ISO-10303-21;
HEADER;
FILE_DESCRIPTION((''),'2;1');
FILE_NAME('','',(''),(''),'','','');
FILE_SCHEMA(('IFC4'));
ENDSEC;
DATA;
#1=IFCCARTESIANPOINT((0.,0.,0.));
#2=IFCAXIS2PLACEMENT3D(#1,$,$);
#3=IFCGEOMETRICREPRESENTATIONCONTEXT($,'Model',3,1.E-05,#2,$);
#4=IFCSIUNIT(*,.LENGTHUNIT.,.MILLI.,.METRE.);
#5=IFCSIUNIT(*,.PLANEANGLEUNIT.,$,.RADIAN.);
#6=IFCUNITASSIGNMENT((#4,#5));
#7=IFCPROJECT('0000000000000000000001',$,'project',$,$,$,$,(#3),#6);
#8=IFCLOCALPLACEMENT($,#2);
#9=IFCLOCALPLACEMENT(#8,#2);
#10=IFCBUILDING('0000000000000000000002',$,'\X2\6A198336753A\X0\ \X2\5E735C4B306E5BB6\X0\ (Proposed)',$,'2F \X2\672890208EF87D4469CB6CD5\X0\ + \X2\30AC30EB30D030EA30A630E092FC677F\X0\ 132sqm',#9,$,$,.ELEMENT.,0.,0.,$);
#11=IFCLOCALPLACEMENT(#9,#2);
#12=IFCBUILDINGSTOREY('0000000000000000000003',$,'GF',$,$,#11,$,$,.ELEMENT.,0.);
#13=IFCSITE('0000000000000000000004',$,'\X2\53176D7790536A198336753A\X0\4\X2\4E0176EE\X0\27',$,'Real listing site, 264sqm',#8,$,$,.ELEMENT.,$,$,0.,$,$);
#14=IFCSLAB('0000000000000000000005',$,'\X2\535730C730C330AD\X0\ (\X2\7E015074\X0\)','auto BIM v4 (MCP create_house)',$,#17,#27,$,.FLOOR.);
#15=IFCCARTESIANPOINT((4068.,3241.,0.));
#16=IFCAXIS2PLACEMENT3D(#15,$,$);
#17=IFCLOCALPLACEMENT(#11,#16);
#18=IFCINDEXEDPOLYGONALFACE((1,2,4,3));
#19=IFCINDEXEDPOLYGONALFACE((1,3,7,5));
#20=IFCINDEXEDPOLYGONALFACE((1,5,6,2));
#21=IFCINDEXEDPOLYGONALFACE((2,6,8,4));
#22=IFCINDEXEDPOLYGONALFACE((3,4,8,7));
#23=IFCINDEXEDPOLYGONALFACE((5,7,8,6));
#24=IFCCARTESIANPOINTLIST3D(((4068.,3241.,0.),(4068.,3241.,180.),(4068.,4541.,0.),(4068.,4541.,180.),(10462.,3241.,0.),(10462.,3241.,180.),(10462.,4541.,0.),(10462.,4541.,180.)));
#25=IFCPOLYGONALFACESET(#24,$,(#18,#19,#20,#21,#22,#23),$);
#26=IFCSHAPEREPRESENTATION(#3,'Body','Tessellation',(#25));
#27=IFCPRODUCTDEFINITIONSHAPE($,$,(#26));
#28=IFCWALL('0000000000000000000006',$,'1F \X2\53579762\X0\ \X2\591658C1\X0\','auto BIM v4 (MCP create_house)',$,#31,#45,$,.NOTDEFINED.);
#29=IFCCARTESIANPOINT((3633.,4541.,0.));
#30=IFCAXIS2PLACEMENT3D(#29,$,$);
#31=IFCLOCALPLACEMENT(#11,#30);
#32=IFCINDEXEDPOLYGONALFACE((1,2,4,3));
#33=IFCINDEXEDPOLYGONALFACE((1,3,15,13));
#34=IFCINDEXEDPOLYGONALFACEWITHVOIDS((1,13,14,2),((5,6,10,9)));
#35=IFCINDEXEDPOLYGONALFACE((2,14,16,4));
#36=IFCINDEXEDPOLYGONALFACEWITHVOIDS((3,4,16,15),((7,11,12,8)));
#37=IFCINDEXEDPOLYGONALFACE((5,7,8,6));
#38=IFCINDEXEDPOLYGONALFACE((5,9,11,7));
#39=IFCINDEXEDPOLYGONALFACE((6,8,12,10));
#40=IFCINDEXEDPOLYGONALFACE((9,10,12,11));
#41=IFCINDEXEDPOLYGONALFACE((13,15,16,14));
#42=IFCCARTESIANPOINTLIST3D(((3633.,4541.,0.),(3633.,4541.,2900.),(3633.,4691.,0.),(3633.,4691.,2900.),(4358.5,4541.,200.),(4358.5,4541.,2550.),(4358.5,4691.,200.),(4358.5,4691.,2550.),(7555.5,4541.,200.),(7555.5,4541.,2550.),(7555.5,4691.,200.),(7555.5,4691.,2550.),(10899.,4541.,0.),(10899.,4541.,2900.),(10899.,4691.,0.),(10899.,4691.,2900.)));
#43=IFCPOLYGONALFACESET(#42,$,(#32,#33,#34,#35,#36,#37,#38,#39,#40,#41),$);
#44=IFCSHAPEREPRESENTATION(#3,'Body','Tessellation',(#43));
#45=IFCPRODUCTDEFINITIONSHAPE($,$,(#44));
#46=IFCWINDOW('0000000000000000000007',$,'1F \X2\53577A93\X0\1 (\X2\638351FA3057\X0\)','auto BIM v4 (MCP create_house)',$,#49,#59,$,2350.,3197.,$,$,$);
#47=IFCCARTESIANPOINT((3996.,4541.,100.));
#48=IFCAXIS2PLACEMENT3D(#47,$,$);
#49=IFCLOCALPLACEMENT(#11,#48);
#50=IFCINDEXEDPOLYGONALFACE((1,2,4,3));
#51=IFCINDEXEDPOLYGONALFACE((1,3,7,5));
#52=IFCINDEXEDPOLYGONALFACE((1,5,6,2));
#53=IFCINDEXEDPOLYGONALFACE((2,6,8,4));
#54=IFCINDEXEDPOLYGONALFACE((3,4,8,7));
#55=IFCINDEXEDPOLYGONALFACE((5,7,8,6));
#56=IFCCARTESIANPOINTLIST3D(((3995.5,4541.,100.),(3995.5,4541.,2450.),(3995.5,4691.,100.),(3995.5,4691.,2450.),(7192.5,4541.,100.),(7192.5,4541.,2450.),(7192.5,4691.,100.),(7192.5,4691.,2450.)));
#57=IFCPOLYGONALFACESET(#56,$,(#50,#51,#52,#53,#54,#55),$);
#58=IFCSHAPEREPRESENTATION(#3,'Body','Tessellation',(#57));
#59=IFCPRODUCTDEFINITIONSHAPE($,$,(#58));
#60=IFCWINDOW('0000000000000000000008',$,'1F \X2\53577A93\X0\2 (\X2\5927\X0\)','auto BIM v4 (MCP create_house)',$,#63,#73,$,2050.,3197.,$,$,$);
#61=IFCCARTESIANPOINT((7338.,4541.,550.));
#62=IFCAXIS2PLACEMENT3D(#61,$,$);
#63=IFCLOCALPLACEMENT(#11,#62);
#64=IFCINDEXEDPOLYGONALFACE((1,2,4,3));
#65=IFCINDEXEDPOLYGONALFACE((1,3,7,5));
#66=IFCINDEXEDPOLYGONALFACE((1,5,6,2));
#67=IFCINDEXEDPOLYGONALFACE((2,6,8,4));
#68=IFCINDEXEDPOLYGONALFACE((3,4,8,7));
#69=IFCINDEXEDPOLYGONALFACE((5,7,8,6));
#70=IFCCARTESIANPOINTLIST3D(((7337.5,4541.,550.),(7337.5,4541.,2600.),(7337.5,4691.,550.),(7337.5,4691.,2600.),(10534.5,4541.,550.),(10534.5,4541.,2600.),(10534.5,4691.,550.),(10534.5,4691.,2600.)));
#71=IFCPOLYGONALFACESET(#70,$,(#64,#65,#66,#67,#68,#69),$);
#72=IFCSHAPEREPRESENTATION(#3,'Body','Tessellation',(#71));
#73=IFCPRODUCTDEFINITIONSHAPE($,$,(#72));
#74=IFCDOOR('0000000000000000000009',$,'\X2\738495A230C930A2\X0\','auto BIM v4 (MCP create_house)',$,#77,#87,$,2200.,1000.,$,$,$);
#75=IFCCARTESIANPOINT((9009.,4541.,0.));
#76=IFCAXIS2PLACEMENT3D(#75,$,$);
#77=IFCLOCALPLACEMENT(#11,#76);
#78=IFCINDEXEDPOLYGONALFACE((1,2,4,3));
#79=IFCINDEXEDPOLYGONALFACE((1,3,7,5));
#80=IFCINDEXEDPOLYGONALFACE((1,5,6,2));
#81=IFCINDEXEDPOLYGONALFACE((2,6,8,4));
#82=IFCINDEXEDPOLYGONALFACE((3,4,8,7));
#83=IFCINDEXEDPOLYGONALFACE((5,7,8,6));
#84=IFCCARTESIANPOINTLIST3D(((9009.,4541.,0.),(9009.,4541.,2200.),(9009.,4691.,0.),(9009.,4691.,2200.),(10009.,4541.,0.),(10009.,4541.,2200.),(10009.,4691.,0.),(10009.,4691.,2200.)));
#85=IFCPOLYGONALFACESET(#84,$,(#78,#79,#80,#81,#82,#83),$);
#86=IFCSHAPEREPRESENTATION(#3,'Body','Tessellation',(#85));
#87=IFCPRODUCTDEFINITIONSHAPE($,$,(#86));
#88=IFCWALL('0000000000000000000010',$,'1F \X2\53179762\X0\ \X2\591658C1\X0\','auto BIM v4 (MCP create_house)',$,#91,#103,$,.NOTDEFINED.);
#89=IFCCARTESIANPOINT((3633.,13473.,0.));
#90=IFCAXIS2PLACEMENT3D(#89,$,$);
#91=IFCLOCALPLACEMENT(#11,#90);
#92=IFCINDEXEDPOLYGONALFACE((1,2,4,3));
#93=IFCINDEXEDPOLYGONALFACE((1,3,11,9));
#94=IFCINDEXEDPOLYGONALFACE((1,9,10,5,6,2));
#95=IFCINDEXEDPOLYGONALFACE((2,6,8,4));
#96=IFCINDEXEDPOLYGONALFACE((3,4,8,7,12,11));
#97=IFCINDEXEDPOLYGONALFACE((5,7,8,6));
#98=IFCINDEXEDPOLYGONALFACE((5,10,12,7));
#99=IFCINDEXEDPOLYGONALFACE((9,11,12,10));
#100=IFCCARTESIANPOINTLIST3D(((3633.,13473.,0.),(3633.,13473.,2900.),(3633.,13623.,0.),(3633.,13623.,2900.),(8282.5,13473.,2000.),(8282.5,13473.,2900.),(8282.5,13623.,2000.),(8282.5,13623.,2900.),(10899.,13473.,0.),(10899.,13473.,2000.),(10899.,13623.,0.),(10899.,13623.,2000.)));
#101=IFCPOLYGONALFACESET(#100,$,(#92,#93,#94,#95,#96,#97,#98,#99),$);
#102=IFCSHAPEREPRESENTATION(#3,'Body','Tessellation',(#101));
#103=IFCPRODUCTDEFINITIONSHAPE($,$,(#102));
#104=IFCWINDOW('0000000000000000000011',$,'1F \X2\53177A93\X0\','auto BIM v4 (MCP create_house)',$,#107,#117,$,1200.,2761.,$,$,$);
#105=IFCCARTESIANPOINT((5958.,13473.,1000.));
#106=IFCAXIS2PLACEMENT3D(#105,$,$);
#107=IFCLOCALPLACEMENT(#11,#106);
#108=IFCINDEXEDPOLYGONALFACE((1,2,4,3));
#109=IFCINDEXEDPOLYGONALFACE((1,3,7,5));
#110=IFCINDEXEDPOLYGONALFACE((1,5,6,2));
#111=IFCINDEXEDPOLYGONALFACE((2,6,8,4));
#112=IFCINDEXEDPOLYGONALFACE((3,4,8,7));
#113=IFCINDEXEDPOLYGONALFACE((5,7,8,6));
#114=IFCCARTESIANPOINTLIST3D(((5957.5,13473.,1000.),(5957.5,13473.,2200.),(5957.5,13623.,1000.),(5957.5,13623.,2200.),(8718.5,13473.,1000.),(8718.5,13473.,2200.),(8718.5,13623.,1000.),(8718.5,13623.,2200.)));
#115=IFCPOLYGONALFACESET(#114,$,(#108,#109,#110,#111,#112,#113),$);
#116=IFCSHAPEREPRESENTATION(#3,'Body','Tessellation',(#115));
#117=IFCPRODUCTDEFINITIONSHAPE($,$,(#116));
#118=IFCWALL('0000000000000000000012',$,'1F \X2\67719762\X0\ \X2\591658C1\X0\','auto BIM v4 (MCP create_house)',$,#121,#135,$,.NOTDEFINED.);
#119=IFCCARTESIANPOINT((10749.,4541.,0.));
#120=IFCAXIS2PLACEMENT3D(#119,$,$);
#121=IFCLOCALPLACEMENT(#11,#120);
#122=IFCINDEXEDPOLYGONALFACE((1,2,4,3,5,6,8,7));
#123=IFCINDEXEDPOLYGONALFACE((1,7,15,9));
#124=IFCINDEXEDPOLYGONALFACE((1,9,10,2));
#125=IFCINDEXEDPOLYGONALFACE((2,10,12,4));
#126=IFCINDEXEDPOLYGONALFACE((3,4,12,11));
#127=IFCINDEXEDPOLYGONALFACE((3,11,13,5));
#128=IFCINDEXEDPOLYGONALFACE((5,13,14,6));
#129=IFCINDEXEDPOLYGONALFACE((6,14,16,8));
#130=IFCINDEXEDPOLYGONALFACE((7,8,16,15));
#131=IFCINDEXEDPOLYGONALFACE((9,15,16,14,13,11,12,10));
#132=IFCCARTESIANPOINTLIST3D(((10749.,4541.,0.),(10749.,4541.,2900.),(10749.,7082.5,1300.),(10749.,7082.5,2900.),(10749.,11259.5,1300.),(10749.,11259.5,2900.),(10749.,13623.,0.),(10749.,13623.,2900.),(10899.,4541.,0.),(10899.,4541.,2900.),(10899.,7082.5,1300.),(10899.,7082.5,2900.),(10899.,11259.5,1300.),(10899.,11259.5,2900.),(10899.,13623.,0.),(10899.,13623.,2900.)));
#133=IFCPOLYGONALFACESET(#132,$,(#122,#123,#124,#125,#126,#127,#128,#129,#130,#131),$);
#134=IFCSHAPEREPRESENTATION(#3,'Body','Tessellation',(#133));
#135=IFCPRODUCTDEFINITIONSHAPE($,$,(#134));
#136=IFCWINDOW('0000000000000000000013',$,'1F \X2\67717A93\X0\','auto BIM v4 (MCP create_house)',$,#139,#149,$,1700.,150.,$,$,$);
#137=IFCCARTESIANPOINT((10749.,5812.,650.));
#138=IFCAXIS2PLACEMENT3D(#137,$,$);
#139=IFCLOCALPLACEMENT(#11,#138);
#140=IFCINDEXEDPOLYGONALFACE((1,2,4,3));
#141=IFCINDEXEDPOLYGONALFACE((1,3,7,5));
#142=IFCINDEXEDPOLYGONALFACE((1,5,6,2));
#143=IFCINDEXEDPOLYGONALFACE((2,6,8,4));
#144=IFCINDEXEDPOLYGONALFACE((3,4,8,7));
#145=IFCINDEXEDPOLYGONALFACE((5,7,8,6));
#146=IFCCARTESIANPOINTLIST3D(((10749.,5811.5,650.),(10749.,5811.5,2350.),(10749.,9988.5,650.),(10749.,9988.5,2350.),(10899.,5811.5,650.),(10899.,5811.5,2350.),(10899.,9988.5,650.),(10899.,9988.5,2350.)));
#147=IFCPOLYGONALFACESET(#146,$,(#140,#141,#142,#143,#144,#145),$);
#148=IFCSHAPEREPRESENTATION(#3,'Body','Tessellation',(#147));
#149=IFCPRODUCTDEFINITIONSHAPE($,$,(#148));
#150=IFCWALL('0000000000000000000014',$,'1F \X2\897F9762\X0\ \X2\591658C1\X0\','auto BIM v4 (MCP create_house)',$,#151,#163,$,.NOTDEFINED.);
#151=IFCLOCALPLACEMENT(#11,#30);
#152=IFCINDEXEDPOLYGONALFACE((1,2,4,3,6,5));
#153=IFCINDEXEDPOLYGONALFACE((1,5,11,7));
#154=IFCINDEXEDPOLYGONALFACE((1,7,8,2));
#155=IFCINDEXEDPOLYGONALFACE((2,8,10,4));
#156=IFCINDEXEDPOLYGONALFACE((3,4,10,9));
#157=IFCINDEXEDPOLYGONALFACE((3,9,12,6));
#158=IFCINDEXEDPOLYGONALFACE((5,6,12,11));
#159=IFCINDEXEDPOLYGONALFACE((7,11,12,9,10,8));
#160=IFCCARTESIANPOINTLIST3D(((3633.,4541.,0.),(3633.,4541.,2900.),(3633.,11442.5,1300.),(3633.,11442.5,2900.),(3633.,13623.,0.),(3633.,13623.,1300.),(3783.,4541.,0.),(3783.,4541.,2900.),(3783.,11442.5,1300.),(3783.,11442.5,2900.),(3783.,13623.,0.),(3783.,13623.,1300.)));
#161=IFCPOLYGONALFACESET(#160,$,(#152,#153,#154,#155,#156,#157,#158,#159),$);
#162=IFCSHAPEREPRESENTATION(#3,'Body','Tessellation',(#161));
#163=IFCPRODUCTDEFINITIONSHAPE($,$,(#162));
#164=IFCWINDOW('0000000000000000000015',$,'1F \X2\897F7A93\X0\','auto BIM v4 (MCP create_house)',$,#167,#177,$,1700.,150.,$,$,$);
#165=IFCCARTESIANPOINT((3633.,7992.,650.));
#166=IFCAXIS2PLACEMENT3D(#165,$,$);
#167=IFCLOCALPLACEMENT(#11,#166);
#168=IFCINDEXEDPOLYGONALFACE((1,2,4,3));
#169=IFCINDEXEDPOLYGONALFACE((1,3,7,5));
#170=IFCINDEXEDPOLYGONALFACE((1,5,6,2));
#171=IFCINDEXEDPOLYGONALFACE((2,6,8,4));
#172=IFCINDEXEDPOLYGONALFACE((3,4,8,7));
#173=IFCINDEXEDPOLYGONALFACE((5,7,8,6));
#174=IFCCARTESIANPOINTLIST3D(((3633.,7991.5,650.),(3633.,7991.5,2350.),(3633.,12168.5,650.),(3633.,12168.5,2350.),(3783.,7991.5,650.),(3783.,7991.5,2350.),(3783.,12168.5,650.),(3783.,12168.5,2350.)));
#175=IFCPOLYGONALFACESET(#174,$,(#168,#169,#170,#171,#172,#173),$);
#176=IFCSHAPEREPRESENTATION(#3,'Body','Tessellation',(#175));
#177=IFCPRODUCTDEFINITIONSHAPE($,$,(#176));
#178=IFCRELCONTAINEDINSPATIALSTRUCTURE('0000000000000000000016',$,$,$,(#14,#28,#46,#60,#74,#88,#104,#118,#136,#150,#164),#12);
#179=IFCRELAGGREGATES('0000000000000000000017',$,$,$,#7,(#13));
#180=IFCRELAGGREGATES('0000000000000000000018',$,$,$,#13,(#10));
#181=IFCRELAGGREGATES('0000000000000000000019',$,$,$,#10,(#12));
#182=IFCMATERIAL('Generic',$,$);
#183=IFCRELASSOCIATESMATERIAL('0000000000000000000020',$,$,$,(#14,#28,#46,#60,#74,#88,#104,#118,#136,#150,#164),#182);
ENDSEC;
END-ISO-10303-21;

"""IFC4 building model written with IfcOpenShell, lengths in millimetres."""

from ifc_helpers import new_model, si_unit, frame, frame_2d, origin, place, context, project, spatial, rectangle, extrude, material, element, fill, save


model = new_model("IFC4")

# Units and contexts
model_context = context("Model", 3, precision=1e-05, world=origin())
ifc_project = project(units=[si_unit("LENGTHUNIT", "METRE", prefix="MILLI"), si_unit("PLANEANGLEUNIT", "RADIAN")], contexts=[model_context])

# Site, building, storey
site_placement = place(None, origin())
site = spatial("IfcSite", under=ifc_project, at=site_placement, Name="北海道標茶町4丁目27", ObjectType="Real listing site, 264sqm", CompositionType="ELEMENT", RefElevation=0.0)
building_placement = place(site_placement, origin())
building = spatial("IfcBuilding", under=site, at=building_placement, Name="標茶町 平屋の家 (Proposed)", ObjectType="2F 木造軸組構法 + ガルバリウム鋼板 132sqm", CompositionType="ELEMENT", ElevationOfRefHeight=0.0, ElevationOfTerrain=0.0)
storey_placement = place(building_placement, origin())
storey = spatial("IfcBuildingStorey", under=building, at=storey_placement, Name="GF", CompositionType="ELEMENT", Elevation=0.0)

# Slab
ifc_material = material(Name="Generic")
slab_1_placement = place(storey_placement, frame((4068.0, 3241.0, 0.0)))
element("IfcSlab", 1, at=slab_1_placement, inside=storey, material=ifc_material, Name="南デッキ (縁側)", Description="auto BIM v4 (MCP create_house)", PredefinedType="FLOOR", context=model_context, shape_type="SweptSolid", body=[
    extrude(rectangle(XDim=6394.0, YDim=1300.0, at=frame_2d((3197.0, 650.0))), frame((4068.0, 3241.0, 0.0)), (0.0, 0.0, 1.0), 180.0),
])

# Wall, openings, windows, door
wall_1_placement = place(storey_placement, frame((3633.0, 4541.0, 0.0)))
wall_1 = element("IfcWall", 2, at=wall_1_placement, inside=storey, material=ifc_material, Name="1F 南面 外壁", Description="auto BIM v4 (MCP create_house)", PredefinedType="NOTDEFINED", context=model_context, shape_type="SweptSolid", body=[
    extrude(rectangle(XDim=7266.0, YDim=150.0, at=frame_2d((3633.0, 75.0))), frame((3633.0, 4541.0, 0.0)), (0.0, 0.0, 1.0), 2900.0),
])
opening_1_placement = place(storey_placement, frame((3996.0, 4541.0, 100.0)))
opening_1 = element("IfcOpeningElement", 3, at=opening_1_placement, cuts=wall_1, PredefinedType="NOTDEFINED", context=model_context, shape_type="SweptSolid", body=[
    extrude(rectangle(XDim=3197.0, YDim=150.0, at=frame_2d((1598.0, 75.0))), frame((3996.0, 4541.0, 100.0)), (0.0, 0.0, 1.0), 2350.0),
])
opening_2_placement = place(storey_placement, frame((7338.0, 4541.0, 550.0)))
opening_2 = element("IfcOpeningElement", 4, at=opening_2_placement, cuts=wall_1, PredefinedType="NOTDEFINED", context=model_context, shape_type="SweptSolid", body=[
    extrude(rectangle(XDim=3197.0, YDim=150.0, at=frame_2d((1598.0, 75.0))), frame((7338.0, 4541.0, 550.0)), (0.0, 0.0, 1.0), 2050.0),
])
opening_3_placement = place(storey_placement, frame((9009.0, 4541.0, 0.0)))
opening_3 = element("IfcOpeningElement", 5, at=opening_3_placement, cuts=wall_1, PredefinedType="NOTDEFINED", context=model_context, shape_type="SweptSolid", body=[
    extrude(rectangle(XDim=1000.0, YDim=150.0, at=frame_2d((500.0, 75.0))), frame((9009.0, 4541.0, 0.0)), (0.0, 0.0, 1.0), 2200.0),
])
window_1_placement = place(storey_placement, frame((3996.0, 4541.0, 100.0)))
window_1 = element("IfcWindow", 6, at=window_1_placement, inside=storey, material=ifc_material, Name="1F 南窓1 (掃出し)", Description="auto BIM v4 (MCP create_house)", OverallHeight=2350.0, OverallWidth=3197.0, context=model_context, shape_type="SweptSolid", body=[
    extrude(rectangle(XDim=3197.0, YDim=150.0, at=frame_2d((1598.0, 75.0))), frame((3996.0, 4541.0, 100.0)), (0.0, 0.0, 1.0), 2350.0),
])
fill(opening_1, window_1)
window_2_placement = place(storey_placement, frame((7338.0, 4541.0, 550.0)))
window_2 = element("IfcWindow", 7, at=window_2_placement, inside=storey, material=ifc_material, Name="1F 南窓2 (大)", Description="auto BIM v4 (MCP create_house)", OverallHeight=2050.0, OverallWidth=3197.0, context=model_context, shape_type="SweptSolid", body=[
    extrude(rectangle(XDim=3197.0, YDim=150.0, at=frame_2d((1598.0, 75.0))), frame((7338.0, 4541.0, 550.0)), (0.0, 0.0, 1.0), 2050.0),
])
fill(opening_2, window_2)
door_1_placement = place(storey_placement, frame((9009.0, 4541.0, 0.0)))
door_1 = element("IfcDoor", 8, at=door_1_placement, inside=storey, material=ifc_material, Name="玄関ドア", Description="auto BIM v4 (MCP create_house)", OverallHeight=2200.0, OverallWidth=1000.0, context=model_context, shape_type="SweptSolid", body=[
    extrude(rectangle(XDim=1000.0, YDim=150.0, at=frame_2d((500.0, 75.0))), frame((9009.0, 4541.0, 0.0)), (0.0, 0.0, 1.0), 2200.0),
])
fill(opening_3, door_1)

# Walls, openings, windows
wall_2_placement = place(storey_placement, frame((3633.0, 13473.0, 0.0)))
wall_2 = element("IfcWall", 9, at=wall_2_placement, inside=storey, material=ifc_material, Name="1F 北面 外壁", Description="auto BIM v4 (MCP create_house)", PredefinedType="NOTDEFINED", context=model_context, shape_type="SweptSolid", body=[
    extrude(rectangle(XDim=7266.0, YDim=150.0, at=frame_2d((3633.0, 75.0))), frame((3633.0, 13473.0, 0.0)), (0.0, 0.0, 1.0), 2900.0),
])
opening_4_placement = place(storey_placement, frame((5958.0, 13473.0, 1000.0)))
opening_4 = element("IfcOpeningElement", 10, at=opening_4_placement, cuts=wall_2, PredefinedType="NOTDEFINED", context=model_context, shape_type="SweptSolid", body=[
    extrude(rectangle(XDim=2761.0, YDim=150.0, at=frame_2d((1380.0, 75.0))), frame((5958.0, 13473.0, 1000.0)), (0.0, 0.0, 1.0), 1200.0),
])
window_3_placement = place(storey_placement, frame((5958.0, 13473.0, 1000.0)))
window_3 = element("IfcWindow", 11, at=window_3_placement, inside=storey, material=ifc_material, Name="1F 北窓", Description="auto BIM v4 (MCP create_house)", OverallHeight=1200.0, OverallWidth=2761.0, context=model_context, shape_type="SweptSolid", body=[
    extrude(rectangle(XDim=2761.0, YDim=150.0, at=frame_2d((1380.0, 75.0))), frame((5958.0, 13473.0, 1000.0)), (0.0, 0.0, 1.0), 1200.0),
])
fill(opening_4, window_3)
wall_3_placement = place(storey_placement, frame((10749.0, 4541.0, 0.0)))
wall_3 = element("IfcWall", 12, at=wall_3_placement, inside=storey, material=ifc_material, Name="1F 東面 外壁", Description="auto BIM v4 (MCP create_house)", PredefinedType="NOTDEFINED", context=model_context, shape_type="SweptSolid", body=[
    extrude(rectangle(XDim=150.0, YDim=9082.0, at=frame_2d((75.0, 4541.0))), frame((10749.0, 4541.0, 0.0)), (0.0, 0.0, 1.0), 2900.0),
])
opening_5_placement = place(storey_placement, frame((10749.0, 5812.0, 650.0)))
opening_5 = element("IfcOpeningElement", 13, at=opening_5_placement, cuts=wall_3, PredefinedType="NOTDEFINED", context=model_context, shape_type="SweptSolid", body=[
    extrude(rectangle(XDim=150.0, YDim=4177.0, at=frame_2d((75.0, 2088.0))), frame((10749.0, 5812.0, 650.0)), (0.0, 0.0, 1.0), 1700.0),
])
window_4_placement = place(storey_placement, frame((10749.0, 5812.0, 650.0)))
window_4 = element("IfcWindow", 14, at=window_4_placement, inside=storey, material=ifc_material, Name="1F 東窓", Description="auto BIM v4 (MCP create_house)", OverallHeight=1700.0, OverallWidth=150.0, context=model_context, shape_type="SweptSolid", body=[
    extrude(rectangle(XDim=150.0, YDim=4177.0, at=frame_2d((75.0, 2088.0))), frame((10749.0, 5812.0, 650.0)), (0.0, 0.0, 1.0), 1700.0),
])
fill(opening_5, window_4)
wall_4_placement = place(storey_placement, frame((3633.0, 4541.0, 0.0)))
wall_4 = element("IfcWall", 15, at=wall_4_placement, inside=storey, material=ifc_material, Name="1F 西面 外壁", Description="auto BIM v4 (MCP create_house)", PredefinedType="NOTDEFINED", context=model_context, shape_type="SweptSolid", body=[
    extrude(rectangle(XDim=150.0, YDim=9082.0, at=frame_2d((75.0, 4541.0))), frame((3633.0, 4541.0, 0.0)), (0.0, 0.0, 1.0), 2900.0),
])
opening_6_placement = place(storey_placement, frame((3633.0, 7992.0, 650.0)))
opening_6 = element("IfcOpeningElement", 16, at=opening_6_placement, cuts=wall_4, PredefinedType="NOTDEFINED", context=model_context, shape_type="SweptSolid", body=[
    extrude(rectangle(XDim=150.0, YDim=4177.0, at=frame_2d((75.0, 2088.0))), frame((3633.0, 7992.0, 650.0)), (0.0, 0.0, 1.0), 1700.0),
])
window_5_placement = place(storey_placement, frame((3633.0, 7992.0, 650.0)))
window_5 = element("IfcWindow", 17, at=window_5_placement, inside=storey, material=ifc_material, Name="1F 西窓", Description="auto BIM v4 (MCP create_house)", OverallHeight=1700.0, OverallWidth=150.0, context=model_context, shape_type="SweptSolid", body=[
    extrude(rectangle(XDim=150.0, YDim=4177.0, at=frame_2d((75.0, 2088.0))), frame((3633.0, 7992.0, 650.0)), (0.0, 0.0, 1.0), 1700.0),
])
fill(opening_6, window_5)

save(model, "model.ifc")
